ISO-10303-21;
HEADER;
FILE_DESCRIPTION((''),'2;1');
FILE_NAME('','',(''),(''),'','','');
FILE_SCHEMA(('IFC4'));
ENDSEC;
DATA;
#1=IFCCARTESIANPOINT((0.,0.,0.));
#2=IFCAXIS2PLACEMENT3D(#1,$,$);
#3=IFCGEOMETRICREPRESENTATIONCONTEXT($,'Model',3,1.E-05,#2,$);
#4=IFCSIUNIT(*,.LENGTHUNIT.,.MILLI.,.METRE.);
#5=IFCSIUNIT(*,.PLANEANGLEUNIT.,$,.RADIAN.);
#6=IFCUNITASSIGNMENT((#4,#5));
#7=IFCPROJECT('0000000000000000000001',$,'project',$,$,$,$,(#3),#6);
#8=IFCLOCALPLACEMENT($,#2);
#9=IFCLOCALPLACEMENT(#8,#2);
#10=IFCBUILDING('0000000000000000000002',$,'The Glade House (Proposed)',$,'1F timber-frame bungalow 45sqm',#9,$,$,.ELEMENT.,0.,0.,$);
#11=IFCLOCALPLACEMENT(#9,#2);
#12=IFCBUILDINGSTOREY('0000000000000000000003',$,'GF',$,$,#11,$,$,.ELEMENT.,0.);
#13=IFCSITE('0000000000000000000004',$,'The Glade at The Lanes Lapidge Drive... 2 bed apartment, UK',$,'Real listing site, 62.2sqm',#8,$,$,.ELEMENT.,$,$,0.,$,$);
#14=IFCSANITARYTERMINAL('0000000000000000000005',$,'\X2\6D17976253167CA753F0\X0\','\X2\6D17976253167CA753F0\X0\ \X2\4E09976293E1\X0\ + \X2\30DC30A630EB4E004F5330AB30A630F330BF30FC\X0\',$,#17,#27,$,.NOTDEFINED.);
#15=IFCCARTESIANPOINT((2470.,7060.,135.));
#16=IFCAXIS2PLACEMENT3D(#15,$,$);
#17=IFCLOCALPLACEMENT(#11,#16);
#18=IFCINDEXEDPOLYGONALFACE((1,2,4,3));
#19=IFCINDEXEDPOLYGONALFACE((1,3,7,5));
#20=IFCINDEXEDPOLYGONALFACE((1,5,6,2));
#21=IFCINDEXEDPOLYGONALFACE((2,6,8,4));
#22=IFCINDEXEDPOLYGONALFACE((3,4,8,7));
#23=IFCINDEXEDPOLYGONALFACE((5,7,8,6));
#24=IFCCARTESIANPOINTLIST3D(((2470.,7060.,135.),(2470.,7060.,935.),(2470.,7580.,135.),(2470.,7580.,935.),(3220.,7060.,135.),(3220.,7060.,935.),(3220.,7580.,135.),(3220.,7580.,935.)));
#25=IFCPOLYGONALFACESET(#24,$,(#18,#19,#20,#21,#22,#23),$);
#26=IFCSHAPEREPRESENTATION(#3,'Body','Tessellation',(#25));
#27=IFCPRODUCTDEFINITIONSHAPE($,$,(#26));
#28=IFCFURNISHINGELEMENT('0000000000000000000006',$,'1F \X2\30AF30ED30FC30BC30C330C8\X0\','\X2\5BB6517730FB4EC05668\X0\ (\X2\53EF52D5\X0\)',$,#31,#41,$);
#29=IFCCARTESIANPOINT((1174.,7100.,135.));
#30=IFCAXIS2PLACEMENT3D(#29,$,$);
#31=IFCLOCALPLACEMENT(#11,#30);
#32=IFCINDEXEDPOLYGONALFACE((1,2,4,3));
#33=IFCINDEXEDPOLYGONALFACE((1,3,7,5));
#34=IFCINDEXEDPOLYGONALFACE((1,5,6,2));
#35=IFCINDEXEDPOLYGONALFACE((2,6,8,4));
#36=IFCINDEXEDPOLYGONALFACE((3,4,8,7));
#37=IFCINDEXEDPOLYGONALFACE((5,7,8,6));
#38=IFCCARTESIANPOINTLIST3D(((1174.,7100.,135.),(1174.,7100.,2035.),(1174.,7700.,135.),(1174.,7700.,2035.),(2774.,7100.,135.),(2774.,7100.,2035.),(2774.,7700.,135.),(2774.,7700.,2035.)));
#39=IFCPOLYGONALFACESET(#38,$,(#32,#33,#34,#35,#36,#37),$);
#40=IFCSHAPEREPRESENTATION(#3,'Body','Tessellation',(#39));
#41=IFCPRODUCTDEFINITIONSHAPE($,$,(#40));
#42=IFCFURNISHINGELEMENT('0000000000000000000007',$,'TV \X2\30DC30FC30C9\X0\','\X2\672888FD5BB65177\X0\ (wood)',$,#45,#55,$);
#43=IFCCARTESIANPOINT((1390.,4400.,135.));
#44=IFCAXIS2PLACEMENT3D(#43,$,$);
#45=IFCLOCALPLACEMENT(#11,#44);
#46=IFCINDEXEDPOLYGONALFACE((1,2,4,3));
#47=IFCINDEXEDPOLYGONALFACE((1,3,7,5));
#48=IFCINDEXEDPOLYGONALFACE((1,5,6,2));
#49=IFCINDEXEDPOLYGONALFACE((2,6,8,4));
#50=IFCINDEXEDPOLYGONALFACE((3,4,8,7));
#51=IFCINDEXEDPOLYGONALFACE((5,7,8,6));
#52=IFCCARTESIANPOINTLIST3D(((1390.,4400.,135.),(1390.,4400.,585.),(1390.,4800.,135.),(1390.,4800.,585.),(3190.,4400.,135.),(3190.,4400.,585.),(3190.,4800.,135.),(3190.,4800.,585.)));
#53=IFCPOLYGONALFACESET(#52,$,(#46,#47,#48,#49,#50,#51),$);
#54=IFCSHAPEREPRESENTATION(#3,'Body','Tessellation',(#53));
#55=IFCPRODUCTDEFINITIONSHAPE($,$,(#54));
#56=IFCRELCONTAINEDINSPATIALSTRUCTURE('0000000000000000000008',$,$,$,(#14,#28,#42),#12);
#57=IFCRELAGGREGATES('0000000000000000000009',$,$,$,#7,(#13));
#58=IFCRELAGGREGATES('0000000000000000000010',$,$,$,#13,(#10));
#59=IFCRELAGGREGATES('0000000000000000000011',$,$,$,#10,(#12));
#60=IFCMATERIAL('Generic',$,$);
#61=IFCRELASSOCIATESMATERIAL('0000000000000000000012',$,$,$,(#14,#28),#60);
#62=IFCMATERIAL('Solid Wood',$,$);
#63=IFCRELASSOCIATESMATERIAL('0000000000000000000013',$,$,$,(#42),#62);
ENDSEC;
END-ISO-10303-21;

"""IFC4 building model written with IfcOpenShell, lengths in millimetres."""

from ifc_helpers import new_model, si_unit, frame, frame_2d, origin, place, context, project, spatial, rectangle, extrude, material, element, save


model = new_model("IFC4")

# Units and contexts
model_context = context("Model", 3, precision=1e-05, world=origin())
ifc_project = project(units=[si_unit("LENGTHUNIT", "METRE", prefix="MILLI"), si_unit("PLANEANGLEUNIT", "RADIAN")], contexts=[model_context])

# Site, building, storey
site_placement = place(None, origin())
site = spatial("IfcSite", under=ifc_project, at=site_placement, Name="The Glade at The Lanes Lapidge Drive... 2 bed apartment, UK", ObjectType="Real listing site, 62.2sqm", CompositionType="ELEMENT", RefElevation=0.0)
building_placement = place(site_placement, origin())
building = spatial("IfcBuilding", under=site, at=building_placement, Name="The Glade House (Proposed)", ObjectType="1F timber-frame bungalow 45sqm", CompositionType="ELEMENT", ElevationOfRefHeight=0.0, ElevationOfTerrain=0.0)
storey_placement = place(building_placement, origin())
storey = spatial("IfcBuildingStorey", under=building, at=storey_placement, Name="GF", CompositionType="ELEMENT", Elevation=0.0)

# Shared definitions
ifc_material_1 = material(Name="Solid Wood")

# Shared definitions
ifc_material_2 = material(Name="Generic")

# Sanitary terminal
sanitary_terminal_1_placement = place(storey_placement, frame((2470.0, 7060.0, 135.0)))
element("IfcSanitaryTerminal", 1, at=sanitary_terminal_1_placement, inside=storey, material=ifc_material_2, Name="洗面化粧台", Description="洗面化粧台 三面鏡 + ボウル一体カウンター", PredefinedType="NOTDEFINED", context=model_context, shape_type="SweptSolid", body=[
    extrude(rectangle(XDim=750.0, YDim=520.0, at=frame_2d((375.0, 260.0))), frame((2470.0, 7060.0, 135.0)), (0.0, 0.0, 1.0), 800.0),
])

# Furnishing elements
furnishing_1_placement = place(storey_placement, frame((1174.0, 7100.0, 135.0)))
element("IfcFurnishingElement", 2, at=furnishing_1_placement, inside=storey, material=ifc_material_2, Name="1F クローゼット", Description="家具・什器 (可動)", context=model_context, shape_type="SweptSolid", body=[
    extrude(rectangle(XDim=1600.0, YDim=600.0, at=frame_2d((800.0, 300.0))), frame((1174.0, 7100.0, 135.0)), (0.0, 0.0, 1.0), 1900.0),
])
furnishing_2_placement = place(storey_placement, frame((1390.0, 4400.0, 135.0)))
element("IfcFurnishingElement", 3, at=furnishing_2_placement, inside=storey, material=ifc_material_1, Name="TV ボード", Description="木製家具 (wood)", context=model_context, shape_type="SweptSolid", body=[
    extrude(rectangle(XDim=1800.0, YDim=400.0, at=frame_2d((900.0, 200.0))), frame((1390.0, 4400.0, 135.0)), (0.0, 0.0, 1.0), 450.0),
])

save(model, "model.ifc")
